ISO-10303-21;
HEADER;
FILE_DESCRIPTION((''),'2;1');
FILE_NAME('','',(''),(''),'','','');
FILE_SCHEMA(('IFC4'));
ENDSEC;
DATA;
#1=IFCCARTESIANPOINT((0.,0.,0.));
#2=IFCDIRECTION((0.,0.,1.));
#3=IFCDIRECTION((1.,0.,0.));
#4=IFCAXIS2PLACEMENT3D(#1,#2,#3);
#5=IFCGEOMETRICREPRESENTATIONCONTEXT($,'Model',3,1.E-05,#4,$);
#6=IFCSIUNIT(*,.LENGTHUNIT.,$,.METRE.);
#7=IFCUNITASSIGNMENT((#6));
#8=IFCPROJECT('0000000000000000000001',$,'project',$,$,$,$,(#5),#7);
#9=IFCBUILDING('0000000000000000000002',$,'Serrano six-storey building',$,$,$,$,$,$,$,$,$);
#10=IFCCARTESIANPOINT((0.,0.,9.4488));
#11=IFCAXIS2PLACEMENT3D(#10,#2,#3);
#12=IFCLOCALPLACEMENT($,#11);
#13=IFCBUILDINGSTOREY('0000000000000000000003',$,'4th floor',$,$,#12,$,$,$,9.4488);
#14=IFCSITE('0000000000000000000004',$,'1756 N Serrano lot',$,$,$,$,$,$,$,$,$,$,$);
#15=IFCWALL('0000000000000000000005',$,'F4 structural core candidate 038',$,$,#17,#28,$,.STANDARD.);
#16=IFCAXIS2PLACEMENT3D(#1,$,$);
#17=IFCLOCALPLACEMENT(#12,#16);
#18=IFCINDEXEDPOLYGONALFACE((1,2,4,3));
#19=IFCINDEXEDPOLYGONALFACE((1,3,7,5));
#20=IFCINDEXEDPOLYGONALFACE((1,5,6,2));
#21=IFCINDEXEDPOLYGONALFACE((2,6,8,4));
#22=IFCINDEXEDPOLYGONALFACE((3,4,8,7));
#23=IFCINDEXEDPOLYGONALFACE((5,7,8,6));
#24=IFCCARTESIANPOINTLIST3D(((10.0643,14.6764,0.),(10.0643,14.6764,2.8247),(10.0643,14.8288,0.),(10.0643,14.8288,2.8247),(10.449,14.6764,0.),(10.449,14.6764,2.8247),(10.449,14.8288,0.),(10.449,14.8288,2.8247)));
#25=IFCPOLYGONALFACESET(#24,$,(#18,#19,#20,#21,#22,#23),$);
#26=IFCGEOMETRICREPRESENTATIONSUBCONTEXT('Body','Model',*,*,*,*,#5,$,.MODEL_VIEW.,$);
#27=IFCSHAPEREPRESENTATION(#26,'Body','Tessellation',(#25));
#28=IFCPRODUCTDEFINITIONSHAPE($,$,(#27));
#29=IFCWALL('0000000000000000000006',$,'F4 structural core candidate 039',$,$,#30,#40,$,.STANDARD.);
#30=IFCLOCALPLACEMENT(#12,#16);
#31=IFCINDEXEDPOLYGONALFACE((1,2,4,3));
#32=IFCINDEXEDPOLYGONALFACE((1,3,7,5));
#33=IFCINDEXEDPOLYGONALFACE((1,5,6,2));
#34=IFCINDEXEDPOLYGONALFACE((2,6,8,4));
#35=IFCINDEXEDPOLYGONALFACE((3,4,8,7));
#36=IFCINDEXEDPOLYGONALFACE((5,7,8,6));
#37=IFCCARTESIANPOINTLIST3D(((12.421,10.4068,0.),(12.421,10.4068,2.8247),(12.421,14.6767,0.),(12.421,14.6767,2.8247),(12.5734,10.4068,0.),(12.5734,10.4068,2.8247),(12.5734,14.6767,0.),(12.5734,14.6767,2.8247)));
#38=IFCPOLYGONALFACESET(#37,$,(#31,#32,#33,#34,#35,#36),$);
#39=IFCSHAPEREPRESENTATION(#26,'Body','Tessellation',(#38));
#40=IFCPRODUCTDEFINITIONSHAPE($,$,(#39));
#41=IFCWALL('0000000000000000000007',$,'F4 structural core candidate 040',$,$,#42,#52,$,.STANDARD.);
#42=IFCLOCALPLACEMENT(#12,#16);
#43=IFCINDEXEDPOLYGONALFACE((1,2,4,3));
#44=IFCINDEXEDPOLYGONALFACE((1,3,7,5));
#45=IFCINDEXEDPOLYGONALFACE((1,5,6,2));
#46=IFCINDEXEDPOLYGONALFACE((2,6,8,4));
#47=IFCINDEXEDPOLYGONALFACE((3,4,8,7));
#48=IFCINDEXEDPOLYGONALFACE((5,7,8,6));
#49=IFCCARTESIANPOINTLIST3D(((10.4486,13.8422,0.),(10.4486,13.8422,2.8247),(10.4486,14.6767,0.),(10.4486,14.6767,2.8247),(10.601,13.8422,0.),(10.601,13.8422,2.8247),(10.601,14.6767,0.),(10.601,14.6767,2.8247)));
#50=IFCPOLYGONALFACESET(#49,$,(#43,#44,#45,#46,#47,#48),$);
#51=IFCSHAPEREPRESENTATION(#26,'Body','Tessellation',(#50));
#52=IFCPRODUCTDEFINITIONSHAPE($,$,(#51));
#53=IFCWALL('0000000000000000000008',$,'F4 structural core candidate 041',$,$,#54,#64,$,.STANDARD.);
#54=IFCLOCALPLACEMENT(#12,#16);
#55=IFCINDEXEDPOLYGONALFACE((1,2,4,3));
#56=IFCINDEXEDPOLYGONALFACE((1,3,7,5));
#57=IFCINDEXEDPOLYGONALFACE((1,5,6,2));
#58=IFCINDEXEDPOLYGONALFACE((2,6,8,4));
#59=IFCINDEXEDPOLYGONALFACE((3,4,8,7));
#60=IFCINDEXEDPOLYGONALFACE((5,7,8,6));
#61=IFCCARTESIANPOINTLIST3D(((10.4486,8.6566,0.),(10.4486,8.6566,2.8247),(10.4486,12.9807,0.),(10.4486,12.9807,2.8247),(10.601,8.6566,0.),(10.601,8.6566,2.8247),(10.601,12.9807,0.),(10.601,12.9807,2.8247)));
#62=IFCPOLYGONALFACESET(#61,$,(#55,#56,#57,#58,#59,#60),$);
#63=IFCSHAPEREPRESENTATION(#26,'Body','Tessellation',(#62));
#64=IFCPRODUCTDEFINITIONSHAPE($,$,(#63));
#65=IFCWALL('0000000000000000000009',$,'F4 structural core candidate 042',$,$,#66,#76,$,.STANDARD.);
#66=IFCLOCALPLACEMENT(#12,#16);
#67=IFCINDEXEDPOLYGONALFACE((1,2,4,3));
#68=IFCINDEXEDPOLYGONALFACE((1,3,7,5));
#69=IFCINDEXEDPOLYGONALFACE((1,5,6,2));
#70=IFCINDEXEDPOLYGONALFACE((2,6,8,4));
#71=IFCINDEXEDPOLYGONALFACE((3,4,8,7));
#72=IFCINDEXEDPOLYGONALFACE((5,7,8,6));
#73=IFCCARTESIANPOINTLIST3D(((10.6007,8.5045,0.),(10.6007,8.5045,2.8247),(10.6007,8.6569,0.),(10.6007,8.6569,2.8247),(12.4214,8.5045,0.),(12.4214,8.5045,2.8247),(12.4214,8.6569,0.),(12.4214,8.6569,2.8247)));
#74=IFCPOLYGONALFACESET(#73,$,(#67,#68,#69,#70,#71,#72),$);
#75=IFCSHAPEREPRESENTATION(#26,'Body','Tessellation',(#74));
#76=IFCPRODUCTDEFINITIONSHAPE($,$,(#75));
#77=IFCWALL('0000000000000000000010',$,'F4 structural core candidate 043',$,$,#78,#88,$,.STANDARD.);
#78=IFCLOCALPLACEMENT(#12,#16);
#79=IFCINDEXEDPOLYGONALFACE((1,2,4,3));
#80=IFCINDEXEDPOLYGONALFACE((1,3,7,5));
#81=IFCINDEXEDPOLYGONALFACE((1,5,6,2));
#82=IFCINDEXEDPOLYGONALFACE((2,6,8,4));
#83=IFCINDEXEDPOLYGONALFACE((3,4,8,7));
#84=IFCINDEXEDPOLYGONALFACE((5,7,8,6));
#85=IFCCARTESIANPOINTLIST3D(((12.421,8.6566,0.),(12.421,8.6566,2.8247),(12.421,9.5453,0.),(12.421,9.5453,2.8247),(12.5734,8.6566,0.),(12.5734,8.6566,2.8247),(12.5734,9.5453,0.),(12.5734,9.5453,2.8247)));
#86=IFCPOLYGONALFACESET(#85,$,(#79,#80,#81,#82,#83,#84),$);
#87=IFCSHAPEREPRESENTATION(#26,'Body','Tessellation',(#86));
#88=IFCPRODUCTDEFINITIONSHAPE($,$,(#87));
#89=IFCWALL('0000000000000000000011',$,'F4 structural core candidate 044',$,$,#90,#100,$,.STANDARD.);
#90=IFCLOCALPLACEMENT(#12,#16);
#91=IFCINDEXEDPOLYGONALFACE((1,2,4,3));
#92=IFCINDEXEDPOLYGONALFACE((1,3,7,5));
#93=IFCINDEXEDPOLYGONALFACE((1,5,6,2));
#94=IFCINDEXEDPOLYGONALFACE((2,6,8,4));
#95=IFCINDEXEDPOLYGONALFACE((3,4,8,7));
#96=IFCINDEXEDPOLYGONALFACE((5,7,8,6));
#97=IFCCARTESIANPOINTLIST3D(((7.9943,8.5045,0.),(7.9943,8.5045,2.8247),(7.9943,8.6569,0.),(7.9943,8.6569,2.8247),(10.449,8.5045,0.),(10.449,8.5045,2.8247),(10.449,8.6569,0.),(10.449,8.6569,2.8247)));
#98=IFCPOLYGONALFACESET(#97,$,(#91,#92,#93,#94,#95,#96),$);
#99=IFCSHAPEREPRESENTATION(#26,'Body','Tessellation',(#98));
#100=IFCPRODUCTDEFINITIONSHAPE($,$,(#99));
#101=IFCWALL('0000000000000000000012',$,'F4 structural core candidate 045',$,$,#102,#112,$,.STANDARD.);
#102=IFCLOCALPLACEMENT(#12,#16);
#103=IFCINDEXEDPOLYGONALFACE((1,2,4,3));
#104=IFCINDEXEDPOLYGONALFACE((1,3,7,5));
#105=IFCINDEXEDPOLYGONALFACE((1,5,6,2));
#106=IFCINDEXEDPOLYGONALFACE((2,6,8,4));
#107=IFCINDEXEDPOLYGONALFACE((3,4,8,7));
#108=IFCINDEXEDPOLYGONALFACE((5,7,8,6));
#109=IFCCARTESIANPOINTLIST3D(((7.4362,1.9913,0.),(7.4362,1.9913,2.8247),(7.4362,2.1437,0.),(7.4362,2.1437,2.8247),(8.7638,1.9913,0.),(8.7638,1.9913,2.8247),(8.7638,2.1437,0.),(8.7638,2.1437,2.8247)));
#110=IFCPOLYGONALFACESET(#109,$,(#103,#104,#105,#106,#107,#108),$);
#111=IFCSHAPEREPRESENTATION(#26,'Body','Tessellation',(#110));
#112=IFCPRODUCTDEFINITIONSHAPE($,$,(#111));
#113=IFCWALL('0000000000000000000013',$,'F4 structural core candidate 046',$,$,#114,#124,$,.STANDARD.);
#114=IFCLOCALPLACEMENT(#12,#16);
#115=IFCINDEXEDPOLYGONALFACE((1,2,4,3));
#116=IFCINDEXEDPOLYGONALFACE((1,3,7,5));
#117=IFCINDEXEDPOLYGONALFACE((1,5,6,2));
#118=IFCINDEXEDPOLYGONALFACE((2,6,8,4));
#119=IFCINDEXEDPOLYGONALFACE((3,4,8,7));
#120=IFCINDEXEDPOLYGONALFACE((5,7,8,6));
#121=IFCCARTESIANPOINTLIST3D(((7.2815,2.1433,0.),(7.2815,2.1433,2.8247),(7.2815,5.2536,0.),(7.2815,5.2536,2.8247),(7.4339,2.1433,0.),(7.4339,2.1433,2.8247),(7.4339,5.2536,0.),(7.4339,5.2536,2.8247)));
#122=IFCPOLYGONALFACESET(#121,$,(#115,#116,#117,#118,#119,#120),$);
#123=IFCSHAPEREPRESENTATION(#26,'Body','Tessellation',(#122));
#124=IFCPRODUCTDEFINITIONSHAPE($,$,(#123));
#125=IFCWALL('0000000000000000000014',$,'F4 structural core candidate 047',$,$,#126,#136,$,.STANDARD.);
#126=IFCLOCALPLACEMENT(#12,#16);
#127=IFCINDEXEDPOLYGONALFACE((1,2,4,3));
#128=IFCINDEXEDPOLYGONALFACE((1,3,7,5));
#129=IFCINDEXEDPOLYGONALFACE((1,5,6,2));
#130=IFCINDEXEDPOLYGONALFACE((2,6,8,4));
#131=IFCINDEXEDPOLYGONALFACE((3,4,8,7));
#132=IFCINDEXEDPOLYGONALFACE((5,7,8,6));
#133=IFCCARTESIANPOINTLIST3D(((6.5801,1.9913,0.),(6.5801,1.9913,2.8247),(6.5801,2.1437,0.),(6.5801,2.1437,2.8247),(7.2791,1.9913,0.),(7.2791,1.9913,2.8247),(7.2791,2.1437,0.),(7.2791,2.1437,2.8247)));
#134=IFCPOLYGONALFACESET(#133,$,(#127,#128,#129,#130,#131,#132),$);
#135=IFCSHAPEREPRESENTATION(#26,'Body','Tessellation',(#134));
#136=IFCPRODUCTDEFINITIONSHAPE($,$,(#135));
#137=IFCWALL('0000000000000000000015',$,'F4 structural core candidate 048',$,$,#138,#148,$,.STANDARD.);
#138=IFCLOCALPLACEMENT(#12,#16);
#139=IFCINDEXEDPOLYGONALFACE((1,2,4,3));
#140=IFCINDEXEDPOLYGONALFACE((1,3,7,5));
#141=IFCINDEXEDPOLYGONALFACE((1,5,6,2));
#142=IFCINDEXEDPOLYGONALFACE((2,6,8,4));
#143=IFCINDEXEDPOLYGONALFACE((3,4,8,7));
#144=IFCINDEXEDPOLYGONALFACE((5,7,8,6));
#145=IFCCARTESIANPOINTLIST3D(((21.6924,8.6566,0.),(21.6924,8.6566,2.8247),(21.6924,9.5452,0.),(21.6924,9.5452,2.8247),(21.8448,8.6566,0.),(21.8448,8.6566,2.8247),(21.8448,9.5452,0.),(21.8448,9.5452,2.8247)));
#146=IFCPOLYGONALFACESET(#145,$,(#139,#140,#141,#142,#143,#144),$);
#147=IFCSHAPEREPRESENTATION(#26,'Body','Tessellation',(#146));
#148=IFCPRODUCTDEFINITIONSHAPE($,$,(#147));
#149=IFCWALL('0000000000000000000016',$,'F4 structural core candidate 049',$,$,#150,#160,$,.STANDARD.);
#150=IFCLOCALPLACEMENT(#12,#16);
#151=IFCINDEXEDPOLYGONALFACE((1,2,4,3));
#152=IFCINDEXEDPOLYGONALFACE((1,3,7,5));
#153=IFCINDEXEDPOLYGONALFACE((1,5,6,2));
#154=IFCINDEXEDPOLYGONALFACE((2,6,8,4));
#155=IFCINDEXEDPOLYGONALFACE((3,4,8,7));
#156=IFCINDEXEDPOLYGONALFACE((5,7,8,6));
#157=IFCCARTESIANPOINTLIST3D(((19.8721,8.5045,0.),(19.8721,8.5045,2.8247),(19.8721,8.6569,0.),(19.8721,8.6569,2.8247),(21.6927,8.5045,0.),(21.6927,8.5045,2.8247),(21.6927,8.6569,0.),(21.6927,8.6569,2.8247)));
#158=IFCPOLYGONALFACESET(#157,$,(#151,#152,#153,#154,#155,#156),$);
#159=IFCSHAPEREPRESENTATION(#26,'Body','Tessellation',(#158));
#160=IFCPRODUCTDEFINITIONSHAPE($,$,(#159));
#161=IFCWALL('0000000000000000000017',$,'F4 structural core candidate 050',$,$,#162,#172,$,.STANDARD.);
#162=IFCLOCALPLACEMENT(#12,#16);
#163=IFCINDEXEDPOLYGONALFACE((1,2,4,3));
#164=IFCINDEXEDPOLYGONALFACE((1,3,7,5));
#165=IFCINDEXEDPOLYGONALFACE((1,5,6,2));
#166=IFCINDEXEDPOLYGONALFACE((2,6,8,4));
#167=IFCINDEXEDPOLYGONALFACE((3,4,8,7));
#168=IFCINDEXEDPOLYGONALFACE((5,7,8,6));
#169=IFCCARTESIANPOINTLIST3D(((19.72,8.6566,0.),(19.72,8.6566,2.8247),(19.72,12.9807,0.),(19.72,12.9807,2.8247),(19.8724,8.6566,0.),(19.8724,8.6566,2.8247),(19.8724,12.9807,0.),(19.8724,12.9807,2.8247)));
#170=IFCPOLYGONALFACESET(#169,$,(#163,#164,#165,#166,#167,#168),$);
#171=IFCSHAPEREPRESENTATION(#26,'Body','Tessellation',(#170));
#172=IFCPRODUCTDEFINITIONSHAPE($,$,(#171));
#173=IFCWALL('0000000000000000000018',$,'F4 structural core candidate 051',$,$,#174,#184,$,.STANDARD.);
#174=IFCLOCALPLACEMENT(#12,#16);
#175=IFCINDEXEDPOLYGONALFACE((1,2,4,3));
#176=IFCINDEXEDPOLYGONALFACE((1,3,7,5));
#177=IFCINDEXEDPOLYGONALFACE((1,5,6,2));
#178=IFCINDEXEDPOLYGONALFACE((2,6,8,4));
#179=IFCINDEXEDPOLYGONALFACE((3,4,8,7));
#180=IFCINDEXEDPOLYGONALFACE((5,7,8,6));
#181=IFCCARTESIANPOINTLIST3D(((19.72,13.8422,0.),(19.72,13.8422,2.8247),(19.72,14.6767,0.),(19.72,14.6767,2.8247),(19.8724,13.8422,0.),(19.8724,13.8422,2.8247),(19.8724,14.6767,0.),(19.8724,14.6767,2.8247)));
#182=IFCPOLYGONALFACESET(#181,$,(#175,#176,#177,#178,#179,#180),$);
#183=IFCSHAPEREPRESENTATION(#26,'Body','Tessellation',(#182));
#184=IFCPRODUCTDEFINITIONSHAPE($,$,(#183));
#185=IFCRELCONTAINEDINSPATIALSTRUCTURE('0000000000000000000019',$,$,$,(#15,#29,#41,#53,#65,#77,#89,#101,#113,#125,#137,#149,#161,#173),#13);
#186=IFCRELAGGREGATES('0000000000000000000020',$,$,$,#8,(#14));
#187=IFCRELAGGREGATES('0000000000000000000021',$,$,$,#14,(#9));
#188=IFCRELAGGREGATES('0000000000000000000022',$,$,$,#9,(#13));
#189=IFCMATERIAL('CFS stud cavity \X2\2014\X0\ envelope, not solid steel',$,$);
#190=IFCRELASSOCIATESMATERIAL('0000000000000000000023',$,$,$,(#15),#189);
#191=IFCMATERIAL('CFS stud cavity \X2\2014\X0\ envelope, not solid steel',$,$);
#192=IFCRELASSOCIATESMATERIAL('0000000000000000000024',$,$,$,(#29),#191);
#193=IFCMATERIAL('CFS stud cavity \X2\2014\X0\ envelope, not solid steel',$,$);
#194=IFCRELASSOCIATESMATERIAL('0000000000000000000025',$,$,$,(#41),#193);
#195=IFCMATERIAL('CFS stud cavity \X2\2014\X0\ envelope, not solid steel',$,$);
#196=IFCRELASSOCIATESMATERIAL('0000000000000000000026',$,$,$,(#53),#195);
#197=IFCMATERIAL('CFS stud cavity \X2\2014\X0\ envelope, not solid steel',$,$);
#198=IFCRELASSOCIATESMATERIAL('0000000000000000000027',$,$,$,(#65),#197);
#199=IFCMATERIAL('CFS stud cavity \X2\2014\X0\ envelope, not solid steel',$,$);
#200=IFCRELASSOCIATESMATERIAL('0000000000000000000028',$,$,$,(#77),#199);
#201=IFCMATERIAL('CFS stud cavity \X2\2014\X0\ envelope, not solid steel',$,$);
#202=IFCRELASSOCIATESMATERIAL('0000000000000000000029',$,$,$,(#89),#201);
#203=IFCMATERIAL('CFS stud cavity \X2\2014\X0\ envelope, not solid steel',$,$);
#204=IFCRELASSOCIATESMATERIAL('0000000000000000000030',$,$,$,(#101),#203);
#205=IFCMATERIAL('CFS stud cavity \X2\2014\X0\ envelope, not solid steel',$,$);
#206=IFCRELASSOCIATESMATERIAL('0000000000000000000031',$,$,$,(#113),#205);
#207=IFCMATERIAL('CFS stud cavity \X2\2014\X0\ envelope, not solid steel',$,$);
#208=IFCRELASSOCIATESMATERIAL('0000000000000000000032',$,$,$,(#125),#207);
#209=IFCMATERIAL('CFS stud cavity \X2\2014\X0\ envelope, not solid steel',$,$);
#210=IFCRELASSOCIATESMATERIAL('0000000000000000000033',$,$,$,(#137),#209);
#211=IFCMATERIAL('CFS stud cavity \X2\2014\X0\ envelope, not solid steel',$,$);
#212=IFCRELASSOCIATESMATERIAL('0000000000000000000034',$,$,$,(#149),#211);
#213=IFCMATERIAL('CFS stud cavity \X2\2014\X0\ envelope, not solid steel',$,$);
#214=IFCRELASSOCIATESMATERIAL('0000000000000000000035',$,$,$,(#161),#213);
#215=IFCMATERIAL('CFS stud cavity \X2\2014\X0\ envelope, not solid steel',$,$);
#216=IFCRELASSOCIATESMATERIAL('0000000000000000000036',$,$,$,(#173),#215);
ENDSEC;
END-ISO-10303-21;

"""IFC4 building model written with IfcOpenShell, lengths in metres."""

from ifc_helpers import new_model, si_unit, frame, origin_with_axes, place, context, subcontext, project, spatial, polyline, outline, extrude, material, element, save


model = new_model("IFC4")

# Units and contexts
model_context = context("Model", 3, precision=1e-05, world=origin_with_axes())
body_context = subcontext(model_context, "Body", "Model", "MODEL_VIEW")
ifc_project = project(units=[si_unit("LENGTHUNIT", "METRE")], contexts=[model_context])

# Site, building, storey
site = spatial("IfcSite", under=ifc_project, Name="1756 N Serrano lot")
building = spatial("IfcBuilding", under=site, Name="Serrano six-storey building")
storey_placement = place(None, frame((0.0, 0.0, 9.4488), z_axis=(0.0, 0.0, 1.0), x_axis=(1.0, 0.0, 0.0)))
storey = spatial("IfcBuildingStorey", under=building, at=storey_placement, Name="4th floor", Elevation=9.4488)

# Walls
ifc_material_1 = material(Name="CFS stud cavity — envelope, not solid steel")
wall_1_placement = place(storey_placement, frame((0.0, 0.0, -9.4488), z_axis=(0.0, 0.0, 1.0), x_axis=(1.0, 0.0, 0.0)))
element("IfcWall", 1, at=wall_1_placement, inside=storey, material=ifc_material_1, Name="F4 structural core candidate 038", PredefinedType="STANDARD", context=body_context, shape_type="SweptSolid", body=[
    extrude(outline(polyline([(10.449, 14.8288), (10.449, 14.6764), (10.0643, 14.6764), (10.0643, 14.8288), (10.449, 14.8288)])), frame((0.0, 0.0, 9.4488)), (0.0, 0.0, 1.0), 2.8247),
])
ifc_material_2 = material(Name="CFS stud cavity — envelope, not solid steel")
wall_2_placement = place(storey_placement, frame((0.0, 0.0, -9.4488), z_axis=(0.0, 0.0, 1.0), x_axis=(1.0, 0.0, 0.0)))
element("IfcWall", 2, at=wall_2_placement, inside=storey, material=ifc_material_2, Name="F4 structural core candidate 039", PredefinedType="STANDARD", context=body_context, shape_type="SweptSolid", body=[
    extrude(outline(polyline([(12.5734, 10.4068), (12.421, 10.4068), (12.421, 14.6767), (12.5734, 14.6767), (12.5734, 10.4068)])), frame((0.0, 0.0, 9.4488)), (0.0, 0.0, 1.0), 2.8247),
])
ifc_material_3 = material(Name="CFS stud cavity — envelope, not solid steel")
wall_3_placement = place(storey_placement, frame((0.0, 0.0, -9.4488), z_axis=(0.0, 0.0, 1.0), x_axis=(1.0, 0.0, 0.0)))
element("IfcWall", 3, at=wall_3_placement, inside=storey, material=ifc_material_3, Name="F4 structural core candidate 040", PredefinedType="STANDARD", context=body_context, shape_type="SweptSolid", body=[
    extrude(outline(polyline([(10.601, 13.8422), (10.4486, 13.8422), (10.4486, 14.6767), (10.601, 14.6767), (10.601, 13.8422)])), frame((0.0, 0.0, 9.4488)), (0.0, 0.0, 1.0), 2.8247),
])
ifc_material_4 = material(Name="CFS stud cavity — envelope, not solid steel")
wall_4_placement = place(storey_placement, frame((0.0, 0.0, -9.4488), z_axis=(0.0, 0.0, 1.0), x_axis=(1.0, 0.0, 0.0)))
element("IfcWall", 4, at=wall_4_placement, inside=storey, material=ifc_material_4, Name="F4 structural core candidate 041", PredefinedType="STANDARD", context=body_context, shape_type="SweptSolid", body=[
    extrude(outline(polyline([(10.601, 8.6566), (10.4486, 8.6566), (10.4486, 12.9807), (10.601, 12.9807), (10.601, 8.6566)])), frame((0.0, 0.0, 9.4488)), (0.0, 0.0, 1.0), 2.8247),
])
ifc_material_5 = material(Name="CFS stud cavity — envelope, not solid steel")
wall_5_placement = place(storey_placement, frame((0.0, 0.0, -9.4488), z_axis=(0.0, 0.0, 1.0), x_axis=(1.0, 0.0, 0.0)))
element("IfcWall", 5, at=wall_5_placement, inside=storey, material=ifc_material_5, Name="F4 structural core candidate 042", PredefinedType="STANDARD", context=body_context, shape_type="SweptSolid", body=[
    extrude(outline(polyline([(12.4214, 8.6569), (12.4214, 8.5045), (10.6007, 8.5045), (10.6007, 8.6569), (12.4214, 8.6569)])), frame((0.0, 0.0, 9.4488)), (0.0, 0.0, 1.0), 2.8247),
])
ifc_material_6 = material(Name="CFS stud cavity — envelope, not solid steel")
wall_6_placement = place(storey_placement, frame((0.0, 0.0, -9.4488), z_axis=(0.0, 0.0, 1.0), x_axis=(1.0, 0.0, 0.0)))
element("IfcWall", 6, at=wall_6_placement, inside=storey, material=ifc_material_6, Name="F4 structural core candidate 043", PredefinedType="STANDARD", context=body_context, shape_type="SweptSolid", body=[
    extrude(outline(polyline([(12.5734, 8.6566), (12.421, 8.6566), (12.421, 9.5453), (12.5734, 9.5453), (12.5734, 8.6566)])), frame((0.0, 0.0, 9.4488)), (0.0, 0.0, 1.0), 2.8247),
])
ifc_material_7 = material(Name="CFS stud cavity — envelope, not solid steel")
wall_7_placement = place(storey_placement, frame((0.0, 0.0, -9.4488), z_axis=(0.0, 0.0, 1.0), x_axis=(1.0, 0.0, 0.0)))
element("IfcWall", 7, at=wall_7_placement, inside=storey, material=ifc_material_7, Name="F4 structural core candidate 044", PredefinedType="STANDARD", context=body_context, shape_type="SweptSolid", body=[
    extrude(outline(polyline([(10.449, 8.6569), (10.449, 8.5045), (7.9943, 8.5045), (7.9943, 8.6569), (10.449, 8.6569)])), frame((0.0, 0.0, 9.4488)), (0.0, 0.0, 1.0), 2.8247),
])
ifc_material_8 = material(Name="CFS stud cavity — envelope, not solid steel")
wall_8_placement = place(storey_placement, frame((0.0, 0.0, -9.4488), z_axis=(0.0, 0.0, 1.0), x_axis=(1.0, 0.0, 0.0)))
element("IfcWall", 8, at=wall_8_placement, inside=storey, material=ifc_material_8, Name="F4 structural core candidate 045", PredefinedType="STANDARD", context=body_context, shape_type="SweptSolid", body=[
    extrude(outline(polyline([(8.7638, 2.1437), (8.7638, 1.9913), (7.4362, 1.9913), (7.4362, 2.1437), (8.7638, 2.1437)])), frame((0.0, 0.0, 9.4488)), (0.0, 0.0, 1.0), 2.8247),
])
ifc_material_9 = material(Name="CFS stud cavity — envelope, not solid steel")
wall_9_placement = place(storey_placement, frame((0.0, 0.0, -9.4488), z_axis=(0.0, 0.0, 1.0), x_axis=(1.0, 0.0, 0.0)))
element("IfcWall", 9, at=wall_9_placement, inside=storey, material=ifc_material_9, Name="F4 structural core candidate 046", PredefinedType="STANDARD", context=body_context, shape_type="SweptSolid", body=[
    extrude(outline(polyline([(7.4339, 2.1433), (7.2815, 2.1433), (7.2815, 5.2536), (7.4339, 5.2536), (7.4339, 2.1433)])), frame((0.0, 0.0, 9.4488)), (0.0, 0.0, 1.0), 2.8247),
])
ifc_material_10 = material(Name="CFS stud cavity — envelope, not solid steel")
wall_10_placement = place(storey_placement, frame((0.0, 0.0, -9.4488), z_axis=(0.0, 0.0, 1.0), x_axis=(1.0, 0.0, 0.0)))
element("IfcWall", 10, at=wall_10_placement, inside=storey, material=ifc_material_10, Name="F4 structural core candidate 047", PredefinedType="STANDARD", context=body_context, shape_type="SweptSolid", body=[
    extrude(outline(polyline([(7.2791, 2.1437), (7.2791, 1.9913), (6.5801, 1.9913), (6.5801, 2.1437), (7.2791, 2.1437)])), frame((0.0, 0.0, 9.4488)), (0.0, 0.0, 1.0), 2.8247),
])
ifc_material_11 = material(Name="CFS stud cavity — envelope, not solid steel")
wall_11_placement = place(storey_placement, frame((0.0, 0.0, -9.4488), z_axis=(0.0, 0.0, 1.0), x_axis=(1.0, 0.0, 0.0)))
element("IfcWall", 11, at=wall_11_placement, inside=storey, material=ifc_material_11, Name="F4 structural core candidate 048", PredefinedType="STANDARD", context=body_context, shape_type="SweptSolid", body=[
    extrude(outline(polyline([(21.8448, 8.6566), (21.6924, 8.6566), (21.6924, 9.5452), (21.8448, 9.5452), (21.8448, 8.6566)])), frame((0.0, 0.0, 9.4488)), (0.0, 0.0, 1.0), 2.8247),
])
ifc_material_12 = material(Name="CFS stud cavity — envelope, not solid steel")
wall_12_placement = place(storey_placement, frame((0.0, 0.0, -9.4488), z_axis=(0.0, 0.0, 1.0), x_axis=(1.0, 0.0, 0.0)))
element("IfcWall", 12, at=wall_12_placement, inside=storey, material=ifc_material_12, Name="F4 structural core candidate 049", PredefinedType="STANDARD", context=body_context, shape_type="SweptSolid", body=[
    extrude(outline(polyline([(21.6927, 8.6569), (21.6927, 8.5045), (19.8721, 8.5045), (19.8721, 8.6569), (21.6927, 8.6569)])), frame((0.0, 0.0, 9.4488)), (0.0, 0.0, 1.0), 2.8247),
])
ifc_material_13 = material(Name="CFS stud cavity — envelope, not solid steel")
wall_13_placement = place(storey_placement, frame((0.0, 0.0, -9.4488), z_axis=(0.0, 0.0, 1.0), x_axis=(1.0, 0.0, 0.0)))
element("IfcWall", 13, at=wall_13_placement, inside=storey, material=ifc_material_13, Name="F4 structural core candidate 050", PredefinedType="STANDARD", context=body_context, shape_type="SweptSolid", body=[
    extrude(outline(polyline([(19.8724, 8.6566), (19.72, 8.6566), (19.72, 12.9807), (19.8724, 12.9807), (19.8724, 8.6566)])), frame((0.0, 0.0, 9.4488)), (0.0, 0.0, 1.0), 2.8247),
])
ifc_material_14 = material(Name="CFS stud cavity — envelope, not solid steel")
wall_14_placement = place(storey_placement, frame((0.0, 0.0, -9.4488), z_axis=(0.0, 0.0, 1.0), x_axis=(1.0, 0.0, 0.0)))
element("IfcWall", 14, at=wall_14_placement, inside=storey, material=ifc_material_14, Name="F4 structural core candidate 051", PredefinedType="STANDARD", context=body_context, shape_type="SweptSolid", body=[
    extrude(outline(polyline([(19.8724, 13.8422), (19.72, 13.8422), (19.72, 14.6767), (19.8724, 14.6767), (19.8724, 13.8422)])), frame((0.0, 0.0, 9.4488)), (0.0, 0.0, 1.0), 2.8247),
])

save(model, "model.ifc")
